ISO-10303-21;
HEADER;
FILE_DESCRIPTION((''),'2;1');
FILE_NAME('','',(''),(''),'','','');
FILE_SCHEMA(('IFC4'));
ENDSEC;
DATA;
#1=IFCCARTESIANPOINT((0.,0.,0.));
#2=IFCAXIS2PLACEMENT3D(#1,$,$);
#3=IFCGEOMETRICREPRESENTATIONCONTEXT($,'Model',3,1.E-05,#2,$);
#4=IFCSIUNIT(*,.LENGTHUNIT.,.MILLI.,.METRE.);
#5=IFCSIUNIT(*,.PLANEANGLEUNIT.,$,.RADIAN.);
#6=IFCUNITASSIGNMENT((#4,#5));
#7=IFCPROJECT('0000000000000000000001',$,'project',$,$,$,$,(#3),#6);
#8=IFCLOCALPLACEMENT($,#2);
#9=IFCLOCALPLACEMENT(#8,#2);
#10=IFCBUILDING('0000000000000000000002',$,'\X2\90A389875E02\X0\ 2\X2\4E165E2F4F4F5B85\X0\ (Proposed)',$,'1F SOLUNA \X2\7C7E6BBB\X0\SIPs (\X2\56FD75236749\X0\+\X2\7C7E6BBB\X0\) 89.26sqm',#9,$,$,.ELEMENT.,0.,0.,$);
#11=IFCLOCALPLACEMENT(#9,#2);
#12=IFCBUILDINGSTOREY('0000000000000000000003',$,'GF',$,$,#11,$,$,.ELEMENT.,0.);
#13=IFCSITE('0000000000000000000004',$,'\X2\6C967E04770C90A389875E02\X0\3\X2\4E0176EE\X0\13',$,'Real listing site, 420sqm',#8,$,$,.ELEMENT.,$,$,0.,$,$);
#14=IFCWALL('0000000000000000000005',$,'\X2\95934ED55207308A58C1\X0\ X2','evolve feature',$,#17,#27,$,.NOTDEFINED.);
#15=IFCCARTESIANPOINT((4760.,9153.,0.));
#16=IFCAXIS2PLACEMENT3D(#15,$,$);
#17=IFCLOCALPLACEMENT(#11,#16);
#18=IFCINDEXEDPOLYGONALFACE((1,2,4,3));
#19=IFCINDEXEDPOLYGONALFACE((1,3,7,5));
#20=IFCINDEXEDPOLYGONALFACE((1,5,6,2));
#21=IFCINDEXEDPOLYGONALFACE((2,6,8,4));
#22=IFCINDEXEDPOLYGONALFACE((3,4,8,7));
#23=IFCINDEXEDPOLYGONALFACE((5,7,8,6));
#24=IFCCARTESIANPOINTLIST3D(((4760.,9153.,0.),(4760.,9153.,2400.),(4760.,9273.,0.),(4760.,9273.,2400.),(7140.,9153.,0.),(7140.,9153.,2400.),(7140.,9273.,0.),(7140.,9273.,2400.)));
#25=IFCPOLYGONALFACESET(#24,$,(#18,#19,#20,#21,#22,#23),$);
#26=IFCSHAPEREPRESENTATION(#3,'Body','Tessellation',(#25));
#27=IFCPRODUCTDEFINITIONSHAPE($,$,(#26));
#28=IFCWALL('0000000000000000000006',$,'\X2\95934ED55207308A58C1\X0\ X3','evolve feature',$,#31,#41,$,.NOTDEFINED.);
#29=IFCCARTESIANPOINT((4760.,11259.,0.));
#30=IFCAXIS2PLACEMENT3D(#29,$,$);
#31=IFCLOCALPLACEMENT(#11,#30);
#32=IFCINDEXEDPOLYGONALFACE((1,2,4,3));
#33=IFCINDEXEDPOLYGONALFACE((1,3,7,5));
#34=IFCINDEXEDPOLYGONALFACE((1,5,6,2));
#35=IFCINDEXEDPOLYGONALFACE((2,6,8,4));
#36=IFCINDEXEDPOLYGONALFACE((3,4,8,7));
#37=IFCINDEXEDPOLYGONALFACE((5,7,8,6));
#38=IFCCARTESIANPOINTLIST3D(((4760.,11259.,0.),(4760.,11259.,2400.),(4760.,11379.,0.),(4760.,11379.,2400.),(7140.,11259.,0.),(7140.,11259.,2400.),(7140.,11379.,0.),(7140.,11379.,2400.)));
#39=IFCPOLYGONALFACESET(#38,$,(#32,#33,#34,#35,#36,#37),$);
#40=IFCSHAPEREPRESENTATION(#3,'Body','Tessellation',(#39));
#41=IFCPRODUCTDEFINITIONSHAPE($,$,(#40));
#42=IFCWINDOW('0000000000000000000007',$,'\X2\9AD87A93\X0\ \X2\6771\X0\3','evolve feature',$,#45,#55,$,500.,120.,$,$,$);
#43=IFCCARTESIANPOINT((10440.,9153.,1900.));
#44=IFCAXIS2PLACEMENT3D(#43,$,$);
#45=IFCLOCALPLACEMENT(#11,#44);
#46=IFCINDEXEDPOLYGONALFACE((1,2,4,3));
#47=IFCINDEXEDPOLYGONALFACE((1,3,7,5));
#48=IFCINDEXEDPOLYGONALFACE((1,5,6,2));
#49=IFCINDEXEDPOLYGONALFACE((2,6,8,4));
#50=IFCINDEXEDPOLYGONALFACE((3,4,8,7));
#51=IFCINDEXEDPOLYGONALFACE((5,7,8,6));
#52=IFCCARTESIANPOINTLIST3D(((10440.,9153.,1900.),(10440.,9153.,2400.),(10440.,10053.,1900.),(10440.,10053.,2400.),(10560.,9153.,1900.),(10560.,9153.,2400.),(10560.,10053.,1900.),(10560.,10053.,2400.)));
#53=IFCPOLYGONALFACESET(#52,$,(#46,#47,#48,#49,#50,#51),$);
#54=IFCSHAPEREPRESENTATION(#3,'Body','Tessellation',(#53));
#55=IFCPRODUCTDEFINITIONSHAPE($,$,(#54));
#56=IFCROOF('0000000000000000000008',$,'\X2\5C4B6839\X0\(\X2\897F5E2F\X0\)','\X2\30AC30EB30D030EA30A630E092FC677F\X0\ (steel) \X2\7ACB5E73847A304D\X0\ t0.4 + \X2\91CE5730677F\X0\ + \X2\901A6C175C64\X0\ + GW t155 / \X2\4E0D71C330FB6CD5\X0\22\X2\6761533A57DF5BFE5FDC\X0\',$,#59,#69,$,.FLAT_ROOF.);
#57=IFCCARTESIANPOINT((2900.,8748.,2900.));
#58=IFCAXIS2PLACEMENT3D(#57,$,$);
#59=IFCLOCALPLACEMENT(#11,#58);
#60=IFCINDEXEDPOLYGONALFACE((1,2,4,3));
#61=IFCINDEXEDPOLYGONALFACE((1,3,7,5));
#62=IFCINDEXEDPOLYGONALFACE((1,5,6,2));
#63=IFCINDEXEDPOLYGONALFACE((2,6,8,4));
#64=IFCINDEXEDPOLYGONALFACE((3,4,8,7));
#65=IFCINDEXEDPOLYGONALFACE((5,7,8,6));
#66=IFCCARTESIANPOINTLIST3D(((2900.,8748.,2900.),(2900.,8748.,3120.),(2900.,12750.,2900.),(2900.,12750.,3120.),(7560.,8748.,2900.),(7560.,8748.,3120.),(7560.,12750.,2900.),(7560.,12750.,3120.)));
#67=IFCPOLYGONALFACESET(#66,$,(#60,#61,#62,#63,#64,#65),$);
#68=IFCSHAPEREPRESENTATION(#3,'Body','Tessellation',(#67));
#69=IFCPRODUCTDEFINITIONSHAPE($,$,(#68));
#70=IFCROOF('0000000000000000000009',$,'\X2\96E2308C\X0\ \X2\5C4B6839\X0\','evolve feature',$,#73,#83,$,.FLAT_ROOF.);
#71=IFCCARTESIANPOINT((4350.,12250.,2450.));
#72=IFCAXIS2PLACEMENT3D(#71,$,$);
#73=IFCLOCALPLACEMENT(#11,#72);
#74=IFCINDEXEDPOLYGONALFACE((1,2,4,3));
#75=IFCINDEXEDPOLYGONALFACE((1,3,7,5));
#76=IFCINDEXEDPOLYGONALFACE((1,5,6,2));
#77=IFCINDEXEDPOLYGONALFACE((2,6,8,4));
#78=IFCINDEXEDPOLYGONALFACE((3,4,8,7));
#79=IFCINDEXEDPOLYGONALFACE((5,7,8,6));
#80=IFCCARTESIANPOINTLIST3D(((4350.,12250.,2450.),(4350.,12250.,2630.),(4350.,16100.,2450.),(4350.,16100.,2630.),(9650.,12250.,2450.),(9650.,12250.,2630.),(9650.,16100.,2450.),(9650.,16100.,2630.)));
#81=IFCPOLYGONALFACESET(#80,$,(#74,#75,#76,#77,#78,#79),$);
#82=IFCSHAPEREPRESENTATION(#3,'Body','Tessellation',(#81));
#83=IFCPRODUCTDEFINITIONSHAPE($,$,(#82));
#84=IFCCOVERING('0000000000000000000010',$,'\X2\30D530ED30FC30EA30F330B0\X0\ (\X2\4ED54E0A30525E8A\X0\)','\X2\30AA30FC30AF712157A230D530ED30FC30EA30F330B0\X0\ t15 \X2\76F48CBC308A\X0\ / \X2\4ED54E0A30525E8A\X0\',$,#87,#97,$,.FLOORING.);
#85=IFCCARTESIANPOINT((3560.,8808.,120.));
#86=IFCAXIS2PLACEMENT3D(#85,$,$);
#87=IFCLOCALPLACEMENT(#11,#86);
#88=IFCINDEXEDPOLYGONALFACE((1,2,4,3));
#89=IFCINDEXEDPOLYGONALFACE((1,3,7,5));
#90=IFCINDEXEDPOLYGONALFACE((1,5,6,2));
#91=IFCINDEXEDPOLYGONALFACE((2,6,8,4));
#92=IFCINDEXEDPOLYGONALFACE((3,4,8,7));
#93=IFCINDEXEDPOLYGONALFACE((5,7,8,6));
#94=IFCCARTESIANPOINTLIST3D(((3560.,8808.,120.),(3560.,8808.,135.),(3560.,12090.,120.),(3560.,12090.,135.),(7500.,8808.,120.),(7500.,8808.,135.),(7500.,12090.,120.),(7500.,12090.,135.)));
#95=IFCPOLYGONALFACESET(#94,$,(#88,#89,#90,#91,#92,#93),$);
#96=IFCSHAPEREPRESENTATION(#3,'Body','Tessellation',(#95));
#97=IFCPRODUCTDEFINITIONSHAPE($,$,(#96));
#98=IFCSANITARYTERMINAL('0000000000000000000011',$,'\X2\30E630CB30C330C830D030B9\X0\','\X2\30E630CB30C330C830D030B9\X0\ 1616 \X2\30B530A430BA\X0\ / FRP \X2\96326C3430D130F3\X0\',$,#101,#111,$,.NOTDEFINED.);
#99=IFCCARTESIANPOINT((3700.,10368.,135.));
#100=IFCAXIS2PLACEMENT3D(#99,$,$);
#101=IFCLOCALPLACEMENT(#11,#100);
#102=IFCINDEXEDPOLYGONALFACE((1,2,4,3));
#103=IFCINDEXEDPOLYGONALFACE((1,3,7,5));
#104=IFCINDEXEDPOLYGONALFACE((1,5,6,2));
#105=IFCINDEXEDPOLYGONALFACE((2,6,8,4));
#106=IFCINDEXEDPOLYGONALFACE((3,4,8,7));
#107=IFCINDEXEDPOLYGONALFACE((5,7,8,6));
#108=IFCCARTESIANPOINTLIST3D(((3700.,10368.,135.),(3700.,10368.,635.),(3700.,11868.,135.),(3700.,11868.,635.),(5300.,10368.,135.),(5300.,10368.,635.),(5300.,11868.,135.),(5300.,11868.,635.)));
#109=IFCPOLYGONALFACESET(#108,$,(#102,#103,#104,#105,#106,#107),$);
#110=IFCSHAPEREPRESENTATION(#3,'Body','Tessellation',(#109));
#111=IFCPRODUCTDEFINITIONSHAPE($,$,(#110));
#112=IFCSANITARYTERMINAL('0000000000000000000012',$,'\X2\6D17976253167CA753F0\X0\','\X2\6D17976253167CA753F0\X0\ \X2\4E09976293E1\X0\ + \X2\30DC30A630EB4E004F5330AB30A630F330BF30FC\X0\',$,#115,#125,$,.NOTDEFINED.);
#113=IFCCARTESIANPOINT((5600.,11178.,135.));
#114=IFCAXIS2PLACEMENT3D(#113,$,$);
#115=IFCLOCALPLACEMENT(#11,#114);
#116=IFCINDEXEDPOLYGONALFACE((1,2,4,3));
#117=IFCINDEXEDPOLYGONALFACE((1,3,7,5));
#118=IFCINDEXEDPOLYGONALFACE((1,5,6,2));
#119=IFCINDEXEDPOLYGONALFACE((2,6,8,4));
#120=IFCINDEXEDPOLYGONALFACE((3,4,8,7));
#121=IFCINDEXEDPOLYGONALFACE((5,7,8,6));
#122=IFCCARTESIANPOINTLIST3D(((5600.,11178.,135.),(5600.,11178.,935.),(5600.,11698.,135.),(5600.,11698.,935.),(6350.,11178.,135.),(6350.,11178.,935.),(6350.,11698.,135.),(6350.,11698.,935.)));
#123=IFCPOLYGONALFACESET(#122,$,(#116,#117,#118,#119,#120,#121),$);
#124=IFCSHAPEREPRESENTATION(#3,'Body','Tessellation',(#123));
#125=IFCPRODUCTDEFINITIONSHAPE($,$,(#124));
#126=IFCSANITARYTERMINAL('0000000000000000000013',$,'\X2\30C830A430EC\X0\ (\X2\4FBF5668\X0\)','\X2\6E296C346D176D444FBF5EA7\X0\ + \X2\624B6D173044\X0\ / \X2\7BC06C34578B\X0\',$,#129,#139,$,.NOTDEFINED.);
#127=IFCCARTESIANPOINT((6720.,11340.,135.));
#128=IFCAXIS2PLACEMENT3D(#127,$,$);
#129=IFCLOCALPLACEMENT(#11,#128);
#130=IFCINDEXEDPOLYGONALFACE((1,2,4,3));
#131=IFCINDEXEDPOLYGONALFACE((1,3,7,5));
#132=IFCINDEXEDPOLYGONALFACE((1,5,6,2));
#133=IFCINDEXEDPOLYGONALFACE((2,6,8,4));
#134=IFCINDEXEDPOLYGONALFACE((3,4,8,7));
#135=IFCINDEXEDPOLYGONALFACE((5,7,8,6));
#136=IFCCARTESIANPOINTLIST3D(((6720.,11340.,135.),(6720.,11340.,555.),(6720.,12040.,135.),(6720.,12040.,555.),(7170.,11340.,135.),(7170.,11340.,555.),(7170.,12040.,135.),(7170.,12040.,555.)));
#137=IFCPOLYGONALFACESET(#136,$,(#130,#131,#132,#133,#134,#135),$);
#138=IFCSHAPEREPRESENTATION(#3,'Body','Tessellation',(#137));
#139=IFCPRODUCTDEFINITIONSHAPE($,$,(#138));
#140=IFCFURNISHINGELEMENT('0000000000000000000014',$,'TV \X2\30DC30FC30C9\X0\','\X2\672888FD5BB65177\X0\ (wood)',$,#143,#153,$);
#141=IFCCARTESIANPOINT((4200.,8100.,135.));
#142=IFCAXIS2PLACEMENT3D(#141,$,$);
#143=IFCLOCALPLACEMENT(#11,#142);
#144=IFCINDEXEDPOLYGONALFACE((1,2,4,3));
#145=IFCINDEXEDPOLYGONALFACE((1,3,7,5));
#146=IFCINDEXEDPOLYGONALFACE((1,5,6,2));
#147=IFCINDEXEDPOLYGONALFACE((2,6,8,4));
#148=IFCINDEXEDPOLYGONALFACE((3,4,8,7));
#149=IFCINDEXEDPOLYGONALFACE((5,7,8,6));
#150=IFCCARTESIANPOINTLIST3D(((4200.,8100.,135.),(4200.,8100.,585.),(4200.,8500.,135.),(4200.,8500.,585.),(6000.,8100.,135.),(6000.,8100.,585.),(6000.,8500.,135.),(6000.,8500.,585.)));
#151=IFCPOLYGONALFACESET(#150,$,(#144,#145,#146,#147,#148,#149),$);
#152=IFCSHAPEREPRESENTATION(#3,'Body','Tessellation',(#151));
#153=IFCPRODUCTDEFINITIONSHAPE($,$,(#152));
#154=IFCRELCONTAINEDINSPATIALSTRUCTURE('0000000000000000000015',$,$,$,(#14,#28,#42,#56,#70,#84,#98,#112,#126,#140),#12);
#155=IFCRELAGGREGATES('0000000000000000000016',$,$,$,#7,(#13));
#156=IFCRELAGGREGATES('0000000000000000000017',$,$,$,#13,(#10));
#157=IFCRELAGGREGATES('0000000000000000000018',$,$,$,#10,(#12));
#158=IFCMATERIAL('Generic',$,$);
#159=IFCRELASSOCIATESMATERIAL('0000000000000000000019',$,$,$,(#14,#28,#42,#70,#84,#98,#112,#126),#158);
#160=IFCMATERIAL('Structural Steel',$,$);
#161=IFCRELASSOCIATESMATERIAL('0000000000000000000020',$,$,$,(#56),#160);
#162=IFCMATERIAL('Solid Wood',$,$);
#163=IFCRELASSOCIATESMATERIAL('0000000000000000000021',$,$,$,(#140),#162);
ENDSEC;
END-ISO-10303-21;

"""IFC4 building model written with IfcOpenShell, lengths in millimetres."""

from ifc_helpers import new_model, si_unit, frame, frame_2d, origin, place, context, project, spatial, rectangle, extrude, material, element, save


model = new_model("IFC4")

# Units and contexts
model_context = context("Model", 3, precision=1e-05, world=origin())
ifc_project = project(units=[si_unit("LENGTHUNIT", "METRE", prefix="MILLI"), si_unit("PLANEANGLEUNIT", "RADIAN")], contexts=[model_context])

# Site, building, storey
site_placement = place(None, origin())
site = spatial("IfcSite", under=ifc_project, at=site_placement, Name="沖縄県那覇市3丁目13", ObjectType="Real listing site, 420sqm", CompositionType="ELEMENT", RefElevation=0.0)
building_placement = place(site_placement, origin())
building = spatial("IfcBuilding", under=site, at=building_placement, Name="那覇市 2世帯住宅 (Proposed)", ObjectType="1F SOLUNA 籾殻SIPs (国産杉+籾殻) 89.26sqm", CompositionType="ELEMENT", ElevationOfRefHeight=0.0, ElevationOfTerrain=0.0)
storey_placement = place(building_placement, origin())
storey = spatial("IfcBuildingStorey", under=building, at=storey_placement, Name="GF", CompositionType="ELEMENT", Elevation=0.0)

# Shared definitions
ifc_material_1 = material(Name="Solid Wood")
ifc_material_2 = material(Name="Generic")

# Walls
wall_1_placement = place(storey_placement, frame((4760.0, 9153.0, 0.0)))
element("IfcWall", 1, at=wall_1_placement, inside=storey, material=ifc_material_2, Name="間仕切り壁 X2", Description="evolve feature", PredefinedType="NOTDEFINED", context=model_context, shape_type="SweptSolid", body=[
    extrude(rectangle(XDim=2380.0, YDim=120.0, at=frame_2d((1190.0, 60.0))), frame((4760.0, 9153.0, 0.0)), (0.0, 0.0, 1.0), 2400.0),
])
wall_2_placement = place(storey_placement, frame((4760.0, 11259.0, 0.0)))
element("IfcWall", 2, at=wall_2_placement, inside=storey, material=ifc_material_2, Name="間仕切り壁 X3", Description="evolve feature", PredefinedType="NOTDEFINED", context=model_context, shape_type="SweptSolid", body=[
    extrude(rectangle(XDim=2380.0, YDim=120.0, at=frame_2d((1190.0, 60.0))), frame((4760.0, 11259.0, 0.0)), (0.0, 0.0, 1.0), 2400.0),
])

# Window
window_1_placement = place(storey_placement, frame((10440.0, 9153.0, 1900.0)))
element("IfcWindow", 3, at=window_1_placement, inside=storey, material=ifc_material_2, Name="高窓 東3", Description="evolve feature", OverallHeight=500.0, OverallWidth=120.0, context=model_context, shape_type="SweptSolid", body=[
    extrude(rectangle(XDim=120.0, YDim=900.0, at=frame_2d((60.0, 450.0))), frame((10440.0, 9153.0, 1900.0)), (0.0, 0.0, 1.0), 500.0),
])

# Roofs
ifc_material_3 = material(Name="Structural Steel")
roof_1_placement = place(storey_placement, frame((2900.0, 8748.0, 2900.0)))
element("IfcRoof", 4, at=roof_1_placement, inside=storey, material=ifc_material_3, Name="屋根(西帯)", Description="ガルバリウム鋼板 (steel) 立平葺き t0.4 + 野地板 + 通気層 + GW t155 / 不燃・法22条区域対応", PredefinedType="FLAT_ROOF", context=model_context, shape_type="SweptSolid", body=[
    extrude(rectangle(XDim=4660.0, YDim=4002.0, at=frame_2d((2330.0, 2001.0))), frame((2900.0, 8748.0, 2900.0)), (0.0, 0.0, 1.0), 220.0),
])
roof_2_placement = place(storey_placement, frame((4350.0, 12250.0, 2450.0)))
element("IfcRoof", 5, at=roof_2_placement, inside=storey, material=ifc_material_2, Name="離れ 屋根", Description="evolve feature", PredefinedType="FLAT_ROOF", context=model_context, shape_type="SweptSolid", body=[
    extrude(rectangle(XDim=5300.0, YDim=3850.0, at=frame_2d((2650.0, 1925.0))), frame((4350.0, 12250.0, 2450.0)), (0.0, 0.0, 1.0), 180.0),
])

# Covering
covering_placement = place(storey_placement, frame((3560.0, 8808.0, 120.0)))
element("IfcCovering", 6, at=covering_placement, inside=storey, material=ifc_material_2, Name="フローリング (仕上げ床)", Description="オーク無垢フローリング t15 直貼り / 仕上げ床", PredefinedType="FLOORING", context=model_context, shape_type="SweptSolid", body=[
    extrude(rectangle(XDim=3940.0, YDim=3282.0, at=frame_2d((1970.0, 1641.0))), frame((3560.0, 8808.0, 120.0)), (0.0, 0.0, 1.0), 15.0),
])

# Sanitary terminals
sanitary_terminal_1_placement = place(storey_placement, frame((3700.0, 10368.0, 135.0)))
element("IfcSanitaryTerminal", 7, at=sanitary_terminal_1_placement, inside=storey, material=ifc_material_2, Name="ユニットバス", Description="ユニットバス 1616 サイズ / FRP 防水パン", PredefinedType="NOTDEFINED", context=model_context, shape_type="SweptSolid", body=[
    extrude(rectangle(XDim=1600.0, YDim=1500.0, at=frame_2d((800.0, 750.0))), frame((3700.0, 10368.0, 135.0)), (0.0, 0.0, 1.0), 500.0),
])
sanitary_terminal_2_placement = place(storey_placement, frame((5600.0, 11178.0, 135.0)))
element("IfcSanitaryTerminal", 8, at=sanitary_terminal_2_placement, inside=storey, material=ifc_material_2, Name="洗面化粧台", Description="洗面化粧台 三面鏡 + ボウル一体カウンター", PredefinedType="NOTDEFINED", context=model_context, shape_type="SweptSolid", body=[
    extrude(rectangle(XDim=750.0, YDim=520.0, at=frame_2d((375.0, 260.0))), frame((5600.0, 11178.0, 135.0)), (0.0, 0.0, 1.0), 800.0),
])
sanitary_terminal_3_placement = place(storey_placement, frame((6720.0, 11340.0, 135.0)))
element("IfcSanitaryTerminal", 9, at=sanitary_terminal_3_placement, inside=storey, material=ifc_material_2, Name="トイレ (便器)", Description="温水洗浄便座 + 手洗い / 節水型", PredefinedType="NOTDEFINED", context=model_context, shape_type="SweptSolid", body=[
    extrude(rectangle(XDim=450.0, YDim=700.0, at=frame_2d((225.0, 350.0))), frame((6720.0, 11340.0, 135.0)), (0.0, 0.0, 1.0), 420.0),
])

# Furnishing element
furnishing_placement = place(storey_placement, frame((4200.0, 8100.0, 135.0)))
element("IfcFurnishingElement", 10, at=furnishing_placement, inside=storey, material=ifc_material_1, Name="TV ボード", Description="木製家具 (wood)", context=model_context, shape_type="SweptSolid", body=[
    extrude(rectangle(XDim=1800.0, YDim=400.0, at=frame_2d((900.0, 200.0))), frame((4200.0, 8100.0, 135.0)), (0.0, 0.0, 1.0), 450.0),
])

save(model, "model.ifc")
